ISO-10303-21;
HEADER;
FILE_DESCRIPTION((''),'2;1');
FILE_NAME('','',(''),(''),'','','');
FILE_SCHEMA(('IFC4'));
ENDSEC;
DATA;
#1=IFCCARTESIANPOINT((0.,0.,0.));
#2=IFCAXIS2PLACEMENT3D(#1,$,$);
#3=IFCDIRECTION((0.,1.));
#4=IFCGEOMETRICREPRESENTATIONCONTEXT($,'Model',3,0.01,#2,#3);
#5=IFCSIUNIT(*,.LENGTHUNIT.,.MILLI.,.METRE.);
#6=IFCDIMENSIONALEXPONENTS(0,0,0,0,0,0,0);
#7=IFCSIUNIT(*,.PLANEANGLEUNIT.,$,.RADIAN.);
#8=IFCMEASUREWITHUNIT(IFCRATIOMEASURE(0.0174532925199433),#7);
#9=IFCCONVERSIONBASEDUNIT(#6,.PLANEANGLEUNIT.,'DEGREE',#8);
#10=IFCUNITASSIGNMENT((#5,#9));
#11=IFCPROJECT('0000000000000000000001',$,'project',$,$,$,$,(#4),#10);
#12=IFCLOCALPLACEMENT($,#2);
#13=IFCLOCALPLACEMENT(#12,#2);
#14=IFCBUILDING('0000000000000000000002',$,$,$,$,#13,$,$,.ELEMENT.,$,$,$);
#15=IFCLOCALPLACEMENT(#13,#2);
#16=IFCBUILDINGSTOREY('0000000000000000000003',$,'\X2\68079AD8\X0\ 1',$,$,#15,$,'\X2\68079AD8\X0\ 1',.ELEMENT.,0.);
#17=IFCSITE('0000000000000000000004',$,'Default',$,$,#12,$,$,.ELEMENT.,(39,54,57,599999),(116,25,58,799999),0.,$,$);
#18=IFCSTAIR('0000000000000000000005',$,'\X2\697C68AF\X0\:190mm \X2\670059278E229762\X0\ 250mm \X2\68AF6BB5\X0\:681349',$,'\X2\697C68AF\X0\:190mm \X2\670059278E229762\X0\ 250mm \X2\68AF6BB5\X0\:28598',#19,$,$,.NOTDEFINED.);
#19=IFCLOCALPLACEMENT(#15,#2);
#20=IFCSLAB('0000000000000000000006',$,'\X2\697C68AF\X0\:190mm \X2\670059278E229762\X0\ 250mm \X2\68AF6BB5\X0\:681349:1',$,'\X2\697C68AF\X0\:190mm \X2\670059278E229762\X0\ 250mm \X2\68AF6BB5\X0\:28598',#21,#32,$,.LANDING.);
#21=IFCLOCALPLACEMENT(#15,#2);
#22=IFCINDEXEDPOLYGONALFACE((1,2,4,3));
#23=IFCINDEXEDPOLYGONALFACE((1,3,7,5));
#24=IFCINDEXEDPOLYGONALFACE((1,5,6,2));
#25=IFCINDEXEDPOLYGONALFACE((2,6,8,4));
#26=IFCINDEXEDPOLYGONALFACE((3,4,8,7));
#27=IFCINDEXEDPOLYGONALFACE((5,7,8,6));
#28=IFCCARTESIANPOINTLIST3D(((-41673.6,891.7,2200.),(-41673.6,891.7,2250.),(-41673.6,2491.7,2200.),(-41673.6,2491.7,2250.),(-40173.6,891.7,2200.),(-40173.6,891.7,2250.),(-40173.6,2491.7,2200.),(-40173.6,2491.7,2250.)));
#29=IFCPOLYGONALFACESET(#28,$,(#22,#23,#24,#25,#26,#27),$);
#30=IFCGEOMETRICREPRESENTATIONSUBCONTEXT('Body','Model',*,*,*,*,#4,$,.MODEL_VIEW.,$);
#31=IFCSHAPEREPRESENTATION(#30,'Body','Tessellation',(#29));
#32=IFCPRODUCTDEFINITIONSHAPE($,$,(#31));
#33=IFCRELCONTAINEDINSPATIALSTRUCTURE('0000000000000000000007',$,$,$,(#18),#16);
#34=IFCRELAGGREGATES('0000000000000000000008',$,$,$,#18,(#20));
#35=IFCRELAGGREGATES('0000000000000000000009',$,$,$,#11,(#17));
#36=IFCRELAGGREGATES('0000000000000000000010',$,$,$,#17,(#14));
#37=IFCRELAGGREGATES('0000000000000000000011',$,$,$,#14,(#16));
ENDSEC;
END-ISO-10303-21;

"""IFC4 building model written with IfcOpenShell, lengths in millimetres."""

from ifc_helpers import new_model, entity, si_unit, converted_unit, direction, frame, frame_2d, origin, place, context, subcontext, project, spatial, rectangle, extrude, element, aggregate, save


model = new_model("IFC4")

# Units and contexts
model_context = context("Model", 3, precision=0.01, world=origin(), true_north=direction((0.0, 1.0)))
body_context = subcontext(model_context, "Body", "Model", "MODEL_VIEW")
ifc_project = project(units=[si_unit("LENGTHUNIT", "METRE", prefix="MILLI"), converted_unit("PLANEANGLEUNIT", "DEGREE", entity("IfcRatioMeasure", 0.0174532925199433), si_unit("PLANEANGLEUNIT", "RADIAN"), dimensions=[0, 0, 0, 0, 0, 0, 0])], contexts=[model_context])

# Site, building, storey
site_placement = place(None, origin())
site = spatial("IfcSite", under=ifc_project, at=site_placement, Name="Default", CompositionType="ELEMENT", RefLatitude=(39, 54, 57, 599999), RefLongitude=(116, 25, 58, 799999), RefElevation=0.0)
building_placement = place(site_placement, origin())
building = spatial("IfcBuilding", under=site, at=building_placement, CompositionType="ELEMENT")
storey_placement = place(building_placement, origin())
storey = spatial("IfcBuildingStorey", under=building, at=storey_placement, Name="标高 1", LongName="标高 1", CompositionType="ELEMENT", Elevation=0.0)

# Stair, slab
stair_placement = place(storey_placement, origin())
stair = element("IfcStair", 1, at=stair_placement, inside=storey, Name="楼梯:190mm 最大踢面 250mm 梯段:681349", ObjectType="楼梯:190mm 最大踢面 250mm 梯段:28598", PredefinedType="NOTDEFINED")
slab_placement = place(stair_placement, origin())
slab = element("IfcSlab", 2, at=slab_placement, Name="楼梯:190mm 最大踢面 250mm 梯段:681349:1", ObjectType="楼梯:190mm 最大踢面 250mm 梯段:28598", PredefinedType="LANDING", context=body_context, shape_type="SweptSolid", body=[
    extrude(rectangle(XDim=1500.0, YDim=1600.0, at=frame_2d((0.0, 0.0), x_axis=(1.0, 0.0))), frame((-40923.6, 1691.7, 2200.0), z_axis=(0.0, 0.0, 1.0), x_axis=(-1.0, 0.0, 0.0)), (0.0, 0.0, 1.0), 50.0),
])
aggregate(stair, [slab])

save(model, "model.ifc")
